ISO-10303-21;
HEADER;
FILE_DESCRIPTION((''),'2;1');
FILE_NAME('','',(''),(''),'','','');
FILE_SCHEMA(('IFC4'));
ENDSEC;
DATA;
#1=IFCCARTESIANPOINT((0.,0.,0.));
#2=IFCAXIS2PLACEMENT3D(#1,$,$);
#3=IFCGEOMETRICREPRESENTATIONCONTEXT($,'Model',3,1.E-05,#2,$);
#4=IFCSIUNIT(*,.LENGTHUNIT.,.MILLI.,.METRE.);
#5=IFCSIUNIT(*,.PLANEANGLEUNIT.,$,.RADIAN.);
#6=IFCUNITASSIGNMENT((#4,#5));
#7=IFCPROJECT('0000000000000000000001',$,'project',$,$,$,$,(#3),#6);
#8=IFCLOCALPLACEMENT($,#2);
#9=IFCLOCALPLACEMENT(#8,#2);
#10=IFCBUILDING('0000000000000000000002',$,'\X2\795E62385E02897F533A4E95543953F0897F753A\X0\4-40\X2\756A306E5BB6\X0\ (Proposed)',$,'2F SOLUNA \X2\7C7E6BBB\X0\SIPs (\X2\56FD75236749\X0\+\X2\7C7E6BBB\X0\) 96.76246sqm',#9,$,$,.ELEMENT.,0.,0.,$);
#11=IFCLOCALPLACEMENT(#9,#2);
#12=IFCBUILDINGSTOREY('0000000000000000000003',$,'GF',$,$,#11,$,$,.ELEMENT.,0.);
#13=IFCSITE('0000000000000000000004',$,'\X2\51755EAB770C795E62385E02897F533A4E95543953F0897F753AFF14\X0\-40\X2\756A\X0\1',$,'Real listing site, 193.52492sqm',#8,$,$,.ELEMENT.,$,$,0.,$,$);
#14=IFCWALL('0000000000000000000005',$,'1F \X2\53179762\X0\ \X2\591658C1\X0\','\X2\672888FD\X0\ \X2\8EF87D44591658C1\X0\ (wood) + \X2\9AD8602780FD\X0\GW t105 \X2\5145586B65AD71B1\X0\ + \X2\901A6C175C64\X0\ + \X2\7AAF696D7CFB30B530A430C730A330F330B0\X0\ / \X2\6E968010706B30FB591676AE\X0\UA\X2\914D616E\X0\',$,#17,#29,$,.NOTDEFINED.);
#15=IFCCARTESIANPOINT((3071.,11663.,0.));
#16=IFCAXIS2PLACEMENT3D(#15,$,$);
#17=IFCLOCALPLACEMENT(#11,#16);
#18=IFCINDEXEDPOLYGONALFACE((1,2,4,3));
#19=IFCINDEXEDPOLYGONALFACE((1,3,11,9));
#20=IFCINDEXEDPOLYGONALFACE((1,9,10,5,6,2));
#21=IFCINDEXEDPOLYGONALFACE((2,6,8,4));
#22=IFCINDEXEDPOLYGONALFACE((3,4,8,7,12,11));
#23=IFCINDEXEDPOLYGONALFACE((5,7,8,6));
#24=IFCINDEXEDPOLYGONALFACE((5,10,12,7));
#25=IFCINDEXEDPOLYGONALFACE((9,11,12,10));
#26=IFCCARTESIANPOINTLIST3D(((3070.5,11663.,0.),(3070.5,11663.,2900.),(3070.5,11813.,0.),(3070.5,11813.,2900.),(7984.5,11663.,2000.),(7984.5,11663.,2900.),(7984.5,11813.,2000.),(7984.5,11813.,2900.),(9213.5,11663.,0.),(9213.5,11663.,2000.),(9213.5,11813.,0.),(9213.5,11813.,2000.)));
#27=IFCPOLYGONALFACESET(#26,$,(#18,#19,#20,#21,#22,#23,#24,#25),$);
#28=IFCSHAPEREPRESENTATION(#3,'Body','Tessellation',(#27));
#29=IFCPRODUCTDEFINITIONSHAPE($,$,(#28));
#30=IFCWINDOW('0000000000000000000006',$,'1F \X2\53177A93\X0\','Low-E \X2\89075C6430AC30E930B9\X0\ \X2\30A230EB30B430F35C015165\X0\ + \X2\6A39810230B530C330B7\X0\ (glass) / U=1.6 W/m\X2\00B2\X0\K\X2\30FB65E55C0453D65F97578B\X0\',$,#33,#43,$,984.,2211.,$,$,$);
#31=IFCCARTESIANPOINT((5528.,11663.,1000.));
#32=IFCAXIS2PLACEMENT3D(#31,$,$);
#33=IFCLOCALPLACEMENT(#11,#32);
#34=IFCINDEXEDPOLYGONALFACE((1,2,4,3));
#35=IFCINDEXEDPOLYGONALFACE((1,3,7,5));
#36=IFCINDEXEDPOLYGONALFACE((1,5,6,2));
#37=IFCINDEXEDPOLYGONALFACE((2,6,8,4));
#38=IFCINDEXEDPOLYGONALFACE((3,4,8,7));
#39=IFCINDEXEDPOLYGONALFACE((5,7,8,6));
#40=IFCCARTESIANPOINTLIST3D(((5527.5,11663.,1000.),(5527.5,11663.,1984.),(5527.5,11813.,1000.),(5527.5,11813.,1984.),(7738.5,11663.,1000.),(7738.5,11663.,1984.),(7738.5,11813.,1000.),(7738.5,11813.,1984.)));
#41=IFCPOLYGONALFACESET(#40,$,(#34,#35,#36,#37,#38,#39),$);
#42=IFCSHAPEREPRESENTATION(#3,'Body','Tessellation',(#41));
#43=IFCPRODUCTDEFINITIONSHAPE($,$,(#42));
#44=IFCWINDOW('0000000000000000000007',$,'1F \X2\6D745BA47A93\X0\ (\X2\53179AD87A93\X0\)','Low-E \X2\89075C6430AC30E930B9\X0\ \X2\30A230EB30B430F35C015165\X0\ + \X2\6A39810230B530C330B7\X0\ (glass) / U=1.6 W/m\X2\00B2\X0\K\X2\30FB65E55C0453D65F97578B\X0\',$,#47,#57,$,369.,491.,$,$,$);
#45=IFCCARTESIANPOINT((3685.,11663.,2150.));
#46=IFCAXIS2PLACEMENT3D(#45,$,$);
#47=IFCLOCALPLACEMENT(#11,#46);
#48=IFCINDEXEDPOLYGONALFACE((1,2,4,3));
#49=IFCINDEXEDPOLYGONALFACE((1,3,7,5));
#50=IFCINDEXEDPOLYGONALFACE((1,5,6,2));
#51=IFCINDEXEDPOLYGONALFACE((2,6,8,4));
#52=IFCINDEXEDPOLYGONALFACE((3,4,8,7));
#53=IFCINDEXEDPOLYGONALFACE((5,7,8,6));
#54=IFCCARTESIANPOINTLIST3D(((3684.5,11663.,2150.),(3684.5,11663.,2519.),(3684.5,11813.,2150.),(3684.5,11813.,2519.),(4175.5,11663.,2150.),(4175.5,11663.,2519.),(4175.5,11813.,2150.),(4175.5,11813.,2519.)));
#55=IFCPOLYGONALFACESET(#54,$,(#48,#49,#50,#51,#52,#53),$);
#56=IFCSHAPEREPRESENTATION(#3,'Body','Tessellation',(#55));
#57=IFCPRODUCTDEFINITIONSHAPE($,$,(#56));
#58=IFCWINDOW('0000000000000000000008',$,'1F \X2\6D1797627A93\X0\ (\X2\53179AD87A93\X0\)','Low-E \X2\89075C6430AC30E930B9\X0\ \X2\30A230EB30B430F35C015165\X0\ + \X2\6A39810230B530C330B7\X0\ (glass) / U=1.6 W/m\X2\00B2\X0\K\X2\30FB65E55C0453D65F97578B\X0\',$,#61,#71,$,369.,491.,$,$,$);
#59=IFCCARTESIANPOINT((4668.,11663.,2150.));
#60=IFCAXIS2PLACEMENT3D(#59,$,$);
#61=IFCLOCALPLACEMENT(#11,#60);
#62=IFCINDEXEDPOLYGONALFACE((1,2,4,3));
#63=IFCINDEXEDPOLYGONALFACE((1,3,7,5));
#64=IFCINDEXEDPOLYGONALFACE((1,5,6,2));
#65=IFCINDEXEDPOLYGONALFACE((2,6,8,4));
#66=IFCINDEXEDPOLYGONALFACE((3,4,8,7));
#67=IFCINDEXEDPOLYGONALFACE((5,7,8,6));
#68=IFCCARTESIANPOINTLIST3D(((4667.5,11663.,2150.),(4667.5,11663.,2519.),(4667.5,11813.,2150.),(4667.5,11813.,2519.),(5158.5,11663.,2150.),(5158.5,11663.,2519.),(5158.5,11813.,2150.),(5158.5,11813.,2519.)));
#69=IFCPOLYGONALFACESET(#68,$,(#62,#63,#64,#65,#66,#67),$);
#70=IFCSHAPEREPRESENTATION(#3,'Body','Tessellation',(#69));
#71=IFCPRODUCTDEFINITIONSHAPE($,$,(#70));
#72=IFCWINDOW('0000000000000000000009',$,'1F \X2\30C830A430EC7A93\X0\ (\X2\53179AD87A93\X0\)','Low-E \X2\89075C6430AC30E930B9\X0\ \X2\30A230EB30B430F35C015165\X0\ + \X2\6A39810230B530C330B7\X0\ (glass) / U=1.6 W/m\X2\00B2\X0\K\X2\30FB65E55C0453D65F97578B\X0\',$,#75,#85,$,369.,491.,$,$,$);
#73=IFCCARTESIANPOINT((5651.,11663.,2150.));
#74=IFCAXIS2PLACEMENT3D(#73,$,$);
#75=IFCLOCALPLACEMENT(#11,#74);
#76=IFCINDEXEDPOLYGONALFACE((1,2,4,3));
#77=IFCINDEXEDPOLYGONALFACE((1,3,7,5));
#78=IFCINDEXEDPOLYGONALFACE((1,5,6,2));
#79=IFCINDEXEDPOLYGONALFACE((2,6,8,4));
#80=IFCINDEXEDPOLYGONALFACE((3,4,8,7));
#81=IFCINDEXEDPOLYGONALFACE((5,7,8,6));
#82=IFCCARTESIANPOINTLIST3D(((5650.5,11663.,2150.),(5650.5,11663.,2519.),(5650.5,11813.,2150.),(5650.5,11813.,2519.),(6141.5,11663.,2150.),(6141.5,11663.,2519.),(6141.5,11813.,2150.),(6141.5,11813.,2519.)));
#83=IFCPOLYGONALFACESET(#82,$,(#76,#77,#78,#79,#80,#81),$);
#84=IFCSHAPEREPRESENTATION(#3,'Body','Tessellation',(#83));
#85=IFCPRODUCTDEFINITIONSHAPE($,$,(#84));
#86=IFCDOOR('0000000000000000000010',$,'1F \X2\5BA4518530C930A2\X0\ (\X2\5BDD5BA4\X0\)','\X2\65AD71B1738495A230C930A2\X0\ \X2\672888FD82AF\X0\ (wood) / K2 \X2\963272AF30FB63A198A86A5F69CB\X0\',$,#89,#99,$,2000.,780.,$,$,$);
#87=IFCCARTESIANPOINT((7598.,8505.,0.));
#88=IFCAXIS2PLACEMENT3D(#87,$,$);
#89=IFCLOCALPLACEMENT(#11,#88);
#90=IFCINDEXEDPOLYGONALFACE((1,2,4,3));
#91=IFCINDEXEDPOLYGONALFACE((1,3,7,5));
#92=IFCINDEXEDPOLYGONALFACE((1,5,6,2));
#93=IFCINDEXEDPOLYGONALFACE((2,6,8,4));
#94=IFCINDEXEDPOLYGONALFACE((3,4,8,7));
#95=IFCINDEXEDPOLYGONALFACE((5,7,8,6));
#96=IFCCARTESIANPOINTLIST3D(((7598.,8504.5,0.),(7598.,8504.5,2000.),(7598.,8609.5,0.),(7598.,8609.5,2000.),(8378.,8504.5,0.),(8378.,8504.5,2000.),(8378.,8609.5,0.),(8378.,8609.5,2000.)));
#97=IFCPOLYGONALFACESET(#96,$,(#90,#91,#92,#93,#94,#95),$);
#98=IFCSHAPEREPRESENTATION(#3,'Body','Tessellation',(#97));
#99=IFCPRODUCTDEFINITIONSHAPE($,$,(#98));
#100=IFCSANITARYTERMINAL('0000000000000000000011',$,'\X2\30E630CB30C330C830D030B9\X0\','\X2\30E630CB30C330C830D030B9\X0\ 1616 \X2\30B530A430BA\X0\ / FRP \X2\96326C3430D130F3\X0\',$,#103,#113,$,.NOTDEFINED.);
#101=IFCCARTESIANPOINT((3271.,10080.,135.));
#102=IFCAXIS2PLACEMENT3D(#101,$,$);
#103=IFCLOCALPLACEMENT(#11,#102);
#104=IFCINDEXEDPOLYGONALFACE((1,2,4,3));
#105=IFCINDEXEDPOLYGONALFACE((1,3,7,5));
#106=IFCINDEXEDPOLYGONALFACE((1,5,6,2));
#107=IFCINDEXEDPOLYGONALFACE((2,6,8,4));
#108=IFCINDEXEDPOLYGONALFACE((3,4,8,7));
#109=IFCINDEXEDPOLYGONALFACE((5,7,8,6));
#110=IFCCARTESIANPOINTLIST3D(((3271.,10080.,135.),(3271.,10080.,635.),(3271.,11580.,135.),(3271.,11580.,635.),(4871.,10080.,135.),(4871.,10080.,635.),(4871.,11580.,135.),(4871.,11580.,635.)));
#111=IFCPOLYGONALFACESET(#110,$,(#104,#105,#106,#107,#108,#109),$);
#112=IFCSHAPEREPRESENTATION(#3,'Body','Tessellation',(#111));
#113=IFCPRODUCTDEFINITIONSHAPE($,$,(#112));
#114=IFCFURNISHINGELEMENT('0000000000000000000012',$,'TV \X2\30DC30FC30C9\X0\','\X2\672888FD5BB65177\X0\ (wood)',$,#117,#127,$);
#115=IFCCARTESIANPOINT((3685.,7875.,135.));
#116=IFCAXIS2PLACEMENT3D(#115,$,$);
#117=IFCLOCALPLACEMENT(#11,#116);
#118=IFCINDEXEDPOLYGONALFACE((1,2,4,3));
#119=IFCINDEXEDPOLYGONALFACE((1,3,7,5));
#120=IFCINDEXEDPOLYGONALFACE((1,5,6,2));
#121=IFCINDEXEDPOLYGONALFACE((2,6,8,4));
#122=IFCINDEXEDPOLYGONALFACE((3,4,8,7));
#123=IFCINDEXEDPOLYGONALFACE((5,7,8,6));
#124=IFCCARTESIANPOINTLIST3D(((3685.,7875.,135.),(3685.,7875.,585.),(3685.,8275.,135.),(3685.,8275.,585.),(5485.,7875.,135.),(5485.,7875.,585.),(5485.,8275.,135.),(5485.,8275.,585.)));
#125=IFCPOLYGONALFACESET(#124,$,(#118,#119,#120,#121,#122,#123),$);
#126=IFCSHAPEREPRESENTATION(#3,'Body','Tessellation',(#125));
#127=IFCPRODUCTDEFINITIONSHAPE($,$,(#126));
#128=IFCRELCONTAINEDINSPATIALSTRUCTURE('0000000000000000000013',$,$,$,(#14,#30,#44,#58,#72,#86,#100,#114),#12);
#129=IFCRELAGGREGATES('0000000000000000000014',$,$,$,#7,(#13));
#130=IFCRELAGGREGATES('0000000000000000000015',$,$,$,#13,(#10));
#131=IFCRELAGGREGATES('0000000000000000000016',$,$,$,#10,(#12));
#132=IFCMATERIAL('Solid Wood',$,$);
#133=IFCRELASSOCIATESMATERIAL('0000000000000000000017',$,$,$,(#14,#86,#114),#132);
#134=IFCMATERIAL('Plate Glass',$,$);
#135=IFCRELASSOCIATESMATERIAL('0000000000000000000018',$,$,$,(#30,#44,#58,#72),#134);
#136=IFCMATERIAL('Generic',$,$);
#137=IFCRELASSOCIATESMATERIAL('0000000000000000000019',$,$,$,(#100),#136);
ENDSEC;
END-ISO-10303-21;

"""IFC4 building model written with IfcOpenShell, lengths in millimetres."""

from ifc_helpers import new_model, si_unit, frame, frame_2d, origin, place, context, project, spatial, rectangle, extrude, material, element, fill, save


model = new_model("IFC4")

# Units and contexts
model_context = context("Model", 3, precision=1e-05, world=origin())
ifc_project = project(units=[si_unit("LENGTHUNIT", "METRE", prefix="MILLI"), si_unit("PLANEANGLEUNIT", "RADIAN")], contexts=[model_context])

# Site, building, storey
site_placement = place(None, origin())
site = spatial("IfcSite", under=ifc_project, at=site_placement, Name="兵庫県神戸市西区井吹台西町４-40番1", ObjectType="Real listing site, 193.52492sqm", CompositionType="ELEMENT", RefElevation=0.0)
building_placement = place(site_placement, origin())
building = spatial("IfcBuilding", under=site, at=building_placement, Name="神戸市西区井吹台西町4-40番の家 (Proposed)", ObjectType="2F SOLUNA 籾殻SIPs (国産杉+籾殻) 96.76246sqm", CompositionType="ELEMENT", ElevationOfRefHeight=0.0, ElevationOfTerrain=0.0)
storey_placement = place(building_placement, origin())
storey = spatial("IfcBuildingStorey", under=building, at=storey_placement, Name="GF", CompositionType="ELEMENT", Elevation=0.0)

# Wall, openings, windows
ifc_material_1 = material(Name="Solid Wood")
wall_1_placement = place(storey_placement, frame((3071.0, 11663.0, 0.0)))
wall_1 = element("IfcWall", 1, at=wall_1_placement, inside=storey, material=ifc_material_1, Name="1F 北面 外壁", Description="木製 軸組外壁 (wood) + 高性能GW t105 充填断熱 + 通気層 + 窯業系サイディング / 準耐火・外皮UA配慮", PredefinedType="NOTDEFINED", context=model_context, shape_type="SweptSolid", body=[
    extrude(rectangle(XDim=6143.0, YDim=150.0, at=frame_2d((3071.0, 75.0))), frame((3071.0, 11663.0, 0.0)), (0.0, 0.0, 1.0), 2900.0),
])
opening_1_placement = place(storey_placement, frame((5528.0, 11663.0, 1000.0)))
opening_1 = element("IfcOpeningElement", 2, at=opening_1_placement, cuts=wall_1, PredefinedType="NOTDEFINED", context=model_context, shape_type="SweptSolid", body=[
    extrude(rectangle(XDim=2211.0, YDim=150.0, at=frame_2d((1105.0, 75.0))), frame((5528.0, 11663.0, 1000.0)), (0.0, 0.0, 1.0), 984.0),
])
opening_2_placement = place(storey_placement, frame((3685.0, 11663.0, 2150.0)))
opening_2 = element("IfcOpeningElement", 3, at=opening_2_placement, cuts=wall_1, PredefinedType="NOTDEFINED", context=model_context, shape_type="SweptSolid", body=[
    extrude(rectangle(XDim=491.0, YDim=150.0, at=frame_2d((245.0, 75.0))), frame((3685.0, 11663.0, 2150.0)), (0.0, 0.0, 1.0), 369.0),
])
opening_3_placement = place(storey_placement, frame((4668.0, 11663.0, 2150.0)))
opening_3 = element("IfcOpeningElement", 4, at=opening_3_placement, cuts=wall_1, PredefinedType="NOTDEFINED", context=model_context, shape_type="SweptSolid", body=[
    extrude(rectangle(XDim=491.0, YDim=150.0, at=frame_2d((245.0, 75.0))), frame((4668.0, 11663.0, 2150.0)), (0.0, 0.0, 1.0), 369.0),
])
opening_4_placement = place(storey_placement, frame((5651.0, 11663.0, 2150.0)))
opening_4 = element("IfcOpeningElement", 5, at=opening_4_placement, cuts=wall_1, PredefinedType="NOTDEFINED", context=model_context, shape_type="SweptSolid", body=[
    extrude(rectangle(XDim=491.0, YDim=150.0, at=frame_2d((245.0, 75.0))), frame((5651.0, 11663.0, 2150.0)), (0.0, 0.0, 1.0), 369.0),
])
ifc_material_2 = material(Name="Plate Glass")
window_1_placement = place(storey_placement, frame((5528.0, 11663.0, 1000.0)))
window_1 = element("IfcWindow", 6, at=window_1_placement, inside=storey, material=ifc_material_2, Name="1F 北窓", Description="Low-E 複層ガラス アルゴン封入 + 樹脂サッシ (glass) / U=1.6 W/m²K・日射取得型", OverallHeight=984.0, OverallWidth=2211.0, context=model_context, shape_type="SweptSolid", body=[
    extrude(rectangle(XDim=2211.0, YDim=150.0, at=frame_2d((1105.0, 75.0))), frame((5528.0, 11663.0, 1000.0)), (0.0, 0.0, 1.0), 984.0),
])
fill(opening_1, window_1)
window_2_placement = place(storey_placement, frame((3685.0, 11663.0, 2150.0)))
window_2 = element("IfcWindow", 7, at=window_2_placement, inside=storey, material=ifc_material_2, Name="1F 浴室窓 (北高窓)", Description="Low-E 複層ガラス アルゴン封入 + 樹脂サッシ (glass) / U=1.6 W/m²K・日射取得型", OverallHeight=369.0, OverallWidth=491.0, context=model_context, shape_type="SweptSolid", body=[
    extrude(rectangle(XDim=491.0, YDim=150.0, at=frame_2d((245.0, 75.0))), frame((3685.0, 11663.0, 2150.0)), (0.0, 0.0, 1.0), 369.0),
])
fill(opening_2, window_2)
window_3_placement = place(storey_placement, frame((4668.0, 11663.0, 2150.0)))
window_3 = element("IfcWindow", 8, at=window_3_placement, inside=storey, material=ifc_material_2, Name="1F 洗面窓 (北高窓)", Description="Low-E 複層ガラス アルゴン封入 + 樹脂サッシ (glass) / U=1.6 W/m²K・日射取得型", OverallHeight=369.0, OverallWidth=491.0, context=model_context, shape_type="SweptSolid", body=[
    extrude(rectangle(XDim=491.0, YDim=150.0, at=frame_2d((245.0, 75.0))), frame((4668.0, 11663.0, 2150.0)), (0.0, 0.0, 1.0), 369.0),
])
fill(opening_3, window_3)
window_4_placement = place(storey_placement, frame((5651.0, 11663.0, 2150.0)))
window_4 = element("IfcWindow", 9, at=window_4_placement, inside=storey, material=ifc_material_2, Name="1F トイレ窓 (北高窓)", Description="Low-E 複層ガラス アルゴン封入 + 樹脂サッシ (glass) / U=1.6 W/m²K・日射取得型", OverallHeight=369.0, OverallWidth=491.0, context=model_context, shape_type="SweptSolid", body=[
    extrude(rectangle(XDim=491.0, YDim=150.0, at=frame_2d((245.0, 75.0))), frame((5651.0, 11663.0, 2150.0)), (0.0, 0.0, 1.0), 369.0),
])
fill(opening_4, window_4)

# Door
door_1_placement = place(storey_placement, frame((7598.0, 8505.0, 0.0)))
element("IfcDoor", 10, at=door_1_placement, inside=storey, material=ifc_material_1, Name="1F 室内ドア (寝室)", Description="断熱玄関ドア 木製芯 (wood) / K2 防犯・採風機構", OverallHeight=2000.0, OverallWidth=780.0, context=model_context, shape_type="SweptSolid", body=[
    extrude(rectangle(XDim=780.0, YDim=105.0, at=frame_2d((390.0, 52.0))), frame((7598.0, 8505.0, 0.0)), (0.0, 0.0, 1.0), 2000.0),
])

# Sanitary terminal
ifc_material_3 = material(Name="Generic")
sanitary_terminal_placement = place(storey_placement, frame((3271.0, 10080.0, 135.0)))
element("IfcSanitaryTerminal", 11, at=sanitary_terminal_placement, inside=storey, material=ifc_material_3, Name="ユニットバス", Description="ユニットバス 1616 サイズ / FRP 防水パン", PredefinedType="NOTDEFINED", context=model_context, shape_type="SweptSolid", body=[
    extrude(rectangle(XDim=1600.0, YDim=1500.0, at=frame_2d((800.0, 750.0))), frame((3271.0, 10080.0, 135.0)), (0.0, 0.0, 1.0), 500.0),
])

# Furnishing element
furnishing_placement = place(storey_placement, frame((3685.0, 7875.0, 135.0)))
element("IfcFurnishingElement", 12, at=furnishing_placement, inside=storey, material=ifc_material_1, Name="TV ボード", Description="木製家具 (wood)", context=model_context, shape_type="SweptSolid", body=[
    extrude(rectangle(XDim=1800.0, YDim=400.0, at=frame_2d((900.0, 200.0))), frame((3685.0, 7875.0, 135.0)), (0.0, 0.0, 1.0), 450.0),
])

save(model, "model.ifc")
